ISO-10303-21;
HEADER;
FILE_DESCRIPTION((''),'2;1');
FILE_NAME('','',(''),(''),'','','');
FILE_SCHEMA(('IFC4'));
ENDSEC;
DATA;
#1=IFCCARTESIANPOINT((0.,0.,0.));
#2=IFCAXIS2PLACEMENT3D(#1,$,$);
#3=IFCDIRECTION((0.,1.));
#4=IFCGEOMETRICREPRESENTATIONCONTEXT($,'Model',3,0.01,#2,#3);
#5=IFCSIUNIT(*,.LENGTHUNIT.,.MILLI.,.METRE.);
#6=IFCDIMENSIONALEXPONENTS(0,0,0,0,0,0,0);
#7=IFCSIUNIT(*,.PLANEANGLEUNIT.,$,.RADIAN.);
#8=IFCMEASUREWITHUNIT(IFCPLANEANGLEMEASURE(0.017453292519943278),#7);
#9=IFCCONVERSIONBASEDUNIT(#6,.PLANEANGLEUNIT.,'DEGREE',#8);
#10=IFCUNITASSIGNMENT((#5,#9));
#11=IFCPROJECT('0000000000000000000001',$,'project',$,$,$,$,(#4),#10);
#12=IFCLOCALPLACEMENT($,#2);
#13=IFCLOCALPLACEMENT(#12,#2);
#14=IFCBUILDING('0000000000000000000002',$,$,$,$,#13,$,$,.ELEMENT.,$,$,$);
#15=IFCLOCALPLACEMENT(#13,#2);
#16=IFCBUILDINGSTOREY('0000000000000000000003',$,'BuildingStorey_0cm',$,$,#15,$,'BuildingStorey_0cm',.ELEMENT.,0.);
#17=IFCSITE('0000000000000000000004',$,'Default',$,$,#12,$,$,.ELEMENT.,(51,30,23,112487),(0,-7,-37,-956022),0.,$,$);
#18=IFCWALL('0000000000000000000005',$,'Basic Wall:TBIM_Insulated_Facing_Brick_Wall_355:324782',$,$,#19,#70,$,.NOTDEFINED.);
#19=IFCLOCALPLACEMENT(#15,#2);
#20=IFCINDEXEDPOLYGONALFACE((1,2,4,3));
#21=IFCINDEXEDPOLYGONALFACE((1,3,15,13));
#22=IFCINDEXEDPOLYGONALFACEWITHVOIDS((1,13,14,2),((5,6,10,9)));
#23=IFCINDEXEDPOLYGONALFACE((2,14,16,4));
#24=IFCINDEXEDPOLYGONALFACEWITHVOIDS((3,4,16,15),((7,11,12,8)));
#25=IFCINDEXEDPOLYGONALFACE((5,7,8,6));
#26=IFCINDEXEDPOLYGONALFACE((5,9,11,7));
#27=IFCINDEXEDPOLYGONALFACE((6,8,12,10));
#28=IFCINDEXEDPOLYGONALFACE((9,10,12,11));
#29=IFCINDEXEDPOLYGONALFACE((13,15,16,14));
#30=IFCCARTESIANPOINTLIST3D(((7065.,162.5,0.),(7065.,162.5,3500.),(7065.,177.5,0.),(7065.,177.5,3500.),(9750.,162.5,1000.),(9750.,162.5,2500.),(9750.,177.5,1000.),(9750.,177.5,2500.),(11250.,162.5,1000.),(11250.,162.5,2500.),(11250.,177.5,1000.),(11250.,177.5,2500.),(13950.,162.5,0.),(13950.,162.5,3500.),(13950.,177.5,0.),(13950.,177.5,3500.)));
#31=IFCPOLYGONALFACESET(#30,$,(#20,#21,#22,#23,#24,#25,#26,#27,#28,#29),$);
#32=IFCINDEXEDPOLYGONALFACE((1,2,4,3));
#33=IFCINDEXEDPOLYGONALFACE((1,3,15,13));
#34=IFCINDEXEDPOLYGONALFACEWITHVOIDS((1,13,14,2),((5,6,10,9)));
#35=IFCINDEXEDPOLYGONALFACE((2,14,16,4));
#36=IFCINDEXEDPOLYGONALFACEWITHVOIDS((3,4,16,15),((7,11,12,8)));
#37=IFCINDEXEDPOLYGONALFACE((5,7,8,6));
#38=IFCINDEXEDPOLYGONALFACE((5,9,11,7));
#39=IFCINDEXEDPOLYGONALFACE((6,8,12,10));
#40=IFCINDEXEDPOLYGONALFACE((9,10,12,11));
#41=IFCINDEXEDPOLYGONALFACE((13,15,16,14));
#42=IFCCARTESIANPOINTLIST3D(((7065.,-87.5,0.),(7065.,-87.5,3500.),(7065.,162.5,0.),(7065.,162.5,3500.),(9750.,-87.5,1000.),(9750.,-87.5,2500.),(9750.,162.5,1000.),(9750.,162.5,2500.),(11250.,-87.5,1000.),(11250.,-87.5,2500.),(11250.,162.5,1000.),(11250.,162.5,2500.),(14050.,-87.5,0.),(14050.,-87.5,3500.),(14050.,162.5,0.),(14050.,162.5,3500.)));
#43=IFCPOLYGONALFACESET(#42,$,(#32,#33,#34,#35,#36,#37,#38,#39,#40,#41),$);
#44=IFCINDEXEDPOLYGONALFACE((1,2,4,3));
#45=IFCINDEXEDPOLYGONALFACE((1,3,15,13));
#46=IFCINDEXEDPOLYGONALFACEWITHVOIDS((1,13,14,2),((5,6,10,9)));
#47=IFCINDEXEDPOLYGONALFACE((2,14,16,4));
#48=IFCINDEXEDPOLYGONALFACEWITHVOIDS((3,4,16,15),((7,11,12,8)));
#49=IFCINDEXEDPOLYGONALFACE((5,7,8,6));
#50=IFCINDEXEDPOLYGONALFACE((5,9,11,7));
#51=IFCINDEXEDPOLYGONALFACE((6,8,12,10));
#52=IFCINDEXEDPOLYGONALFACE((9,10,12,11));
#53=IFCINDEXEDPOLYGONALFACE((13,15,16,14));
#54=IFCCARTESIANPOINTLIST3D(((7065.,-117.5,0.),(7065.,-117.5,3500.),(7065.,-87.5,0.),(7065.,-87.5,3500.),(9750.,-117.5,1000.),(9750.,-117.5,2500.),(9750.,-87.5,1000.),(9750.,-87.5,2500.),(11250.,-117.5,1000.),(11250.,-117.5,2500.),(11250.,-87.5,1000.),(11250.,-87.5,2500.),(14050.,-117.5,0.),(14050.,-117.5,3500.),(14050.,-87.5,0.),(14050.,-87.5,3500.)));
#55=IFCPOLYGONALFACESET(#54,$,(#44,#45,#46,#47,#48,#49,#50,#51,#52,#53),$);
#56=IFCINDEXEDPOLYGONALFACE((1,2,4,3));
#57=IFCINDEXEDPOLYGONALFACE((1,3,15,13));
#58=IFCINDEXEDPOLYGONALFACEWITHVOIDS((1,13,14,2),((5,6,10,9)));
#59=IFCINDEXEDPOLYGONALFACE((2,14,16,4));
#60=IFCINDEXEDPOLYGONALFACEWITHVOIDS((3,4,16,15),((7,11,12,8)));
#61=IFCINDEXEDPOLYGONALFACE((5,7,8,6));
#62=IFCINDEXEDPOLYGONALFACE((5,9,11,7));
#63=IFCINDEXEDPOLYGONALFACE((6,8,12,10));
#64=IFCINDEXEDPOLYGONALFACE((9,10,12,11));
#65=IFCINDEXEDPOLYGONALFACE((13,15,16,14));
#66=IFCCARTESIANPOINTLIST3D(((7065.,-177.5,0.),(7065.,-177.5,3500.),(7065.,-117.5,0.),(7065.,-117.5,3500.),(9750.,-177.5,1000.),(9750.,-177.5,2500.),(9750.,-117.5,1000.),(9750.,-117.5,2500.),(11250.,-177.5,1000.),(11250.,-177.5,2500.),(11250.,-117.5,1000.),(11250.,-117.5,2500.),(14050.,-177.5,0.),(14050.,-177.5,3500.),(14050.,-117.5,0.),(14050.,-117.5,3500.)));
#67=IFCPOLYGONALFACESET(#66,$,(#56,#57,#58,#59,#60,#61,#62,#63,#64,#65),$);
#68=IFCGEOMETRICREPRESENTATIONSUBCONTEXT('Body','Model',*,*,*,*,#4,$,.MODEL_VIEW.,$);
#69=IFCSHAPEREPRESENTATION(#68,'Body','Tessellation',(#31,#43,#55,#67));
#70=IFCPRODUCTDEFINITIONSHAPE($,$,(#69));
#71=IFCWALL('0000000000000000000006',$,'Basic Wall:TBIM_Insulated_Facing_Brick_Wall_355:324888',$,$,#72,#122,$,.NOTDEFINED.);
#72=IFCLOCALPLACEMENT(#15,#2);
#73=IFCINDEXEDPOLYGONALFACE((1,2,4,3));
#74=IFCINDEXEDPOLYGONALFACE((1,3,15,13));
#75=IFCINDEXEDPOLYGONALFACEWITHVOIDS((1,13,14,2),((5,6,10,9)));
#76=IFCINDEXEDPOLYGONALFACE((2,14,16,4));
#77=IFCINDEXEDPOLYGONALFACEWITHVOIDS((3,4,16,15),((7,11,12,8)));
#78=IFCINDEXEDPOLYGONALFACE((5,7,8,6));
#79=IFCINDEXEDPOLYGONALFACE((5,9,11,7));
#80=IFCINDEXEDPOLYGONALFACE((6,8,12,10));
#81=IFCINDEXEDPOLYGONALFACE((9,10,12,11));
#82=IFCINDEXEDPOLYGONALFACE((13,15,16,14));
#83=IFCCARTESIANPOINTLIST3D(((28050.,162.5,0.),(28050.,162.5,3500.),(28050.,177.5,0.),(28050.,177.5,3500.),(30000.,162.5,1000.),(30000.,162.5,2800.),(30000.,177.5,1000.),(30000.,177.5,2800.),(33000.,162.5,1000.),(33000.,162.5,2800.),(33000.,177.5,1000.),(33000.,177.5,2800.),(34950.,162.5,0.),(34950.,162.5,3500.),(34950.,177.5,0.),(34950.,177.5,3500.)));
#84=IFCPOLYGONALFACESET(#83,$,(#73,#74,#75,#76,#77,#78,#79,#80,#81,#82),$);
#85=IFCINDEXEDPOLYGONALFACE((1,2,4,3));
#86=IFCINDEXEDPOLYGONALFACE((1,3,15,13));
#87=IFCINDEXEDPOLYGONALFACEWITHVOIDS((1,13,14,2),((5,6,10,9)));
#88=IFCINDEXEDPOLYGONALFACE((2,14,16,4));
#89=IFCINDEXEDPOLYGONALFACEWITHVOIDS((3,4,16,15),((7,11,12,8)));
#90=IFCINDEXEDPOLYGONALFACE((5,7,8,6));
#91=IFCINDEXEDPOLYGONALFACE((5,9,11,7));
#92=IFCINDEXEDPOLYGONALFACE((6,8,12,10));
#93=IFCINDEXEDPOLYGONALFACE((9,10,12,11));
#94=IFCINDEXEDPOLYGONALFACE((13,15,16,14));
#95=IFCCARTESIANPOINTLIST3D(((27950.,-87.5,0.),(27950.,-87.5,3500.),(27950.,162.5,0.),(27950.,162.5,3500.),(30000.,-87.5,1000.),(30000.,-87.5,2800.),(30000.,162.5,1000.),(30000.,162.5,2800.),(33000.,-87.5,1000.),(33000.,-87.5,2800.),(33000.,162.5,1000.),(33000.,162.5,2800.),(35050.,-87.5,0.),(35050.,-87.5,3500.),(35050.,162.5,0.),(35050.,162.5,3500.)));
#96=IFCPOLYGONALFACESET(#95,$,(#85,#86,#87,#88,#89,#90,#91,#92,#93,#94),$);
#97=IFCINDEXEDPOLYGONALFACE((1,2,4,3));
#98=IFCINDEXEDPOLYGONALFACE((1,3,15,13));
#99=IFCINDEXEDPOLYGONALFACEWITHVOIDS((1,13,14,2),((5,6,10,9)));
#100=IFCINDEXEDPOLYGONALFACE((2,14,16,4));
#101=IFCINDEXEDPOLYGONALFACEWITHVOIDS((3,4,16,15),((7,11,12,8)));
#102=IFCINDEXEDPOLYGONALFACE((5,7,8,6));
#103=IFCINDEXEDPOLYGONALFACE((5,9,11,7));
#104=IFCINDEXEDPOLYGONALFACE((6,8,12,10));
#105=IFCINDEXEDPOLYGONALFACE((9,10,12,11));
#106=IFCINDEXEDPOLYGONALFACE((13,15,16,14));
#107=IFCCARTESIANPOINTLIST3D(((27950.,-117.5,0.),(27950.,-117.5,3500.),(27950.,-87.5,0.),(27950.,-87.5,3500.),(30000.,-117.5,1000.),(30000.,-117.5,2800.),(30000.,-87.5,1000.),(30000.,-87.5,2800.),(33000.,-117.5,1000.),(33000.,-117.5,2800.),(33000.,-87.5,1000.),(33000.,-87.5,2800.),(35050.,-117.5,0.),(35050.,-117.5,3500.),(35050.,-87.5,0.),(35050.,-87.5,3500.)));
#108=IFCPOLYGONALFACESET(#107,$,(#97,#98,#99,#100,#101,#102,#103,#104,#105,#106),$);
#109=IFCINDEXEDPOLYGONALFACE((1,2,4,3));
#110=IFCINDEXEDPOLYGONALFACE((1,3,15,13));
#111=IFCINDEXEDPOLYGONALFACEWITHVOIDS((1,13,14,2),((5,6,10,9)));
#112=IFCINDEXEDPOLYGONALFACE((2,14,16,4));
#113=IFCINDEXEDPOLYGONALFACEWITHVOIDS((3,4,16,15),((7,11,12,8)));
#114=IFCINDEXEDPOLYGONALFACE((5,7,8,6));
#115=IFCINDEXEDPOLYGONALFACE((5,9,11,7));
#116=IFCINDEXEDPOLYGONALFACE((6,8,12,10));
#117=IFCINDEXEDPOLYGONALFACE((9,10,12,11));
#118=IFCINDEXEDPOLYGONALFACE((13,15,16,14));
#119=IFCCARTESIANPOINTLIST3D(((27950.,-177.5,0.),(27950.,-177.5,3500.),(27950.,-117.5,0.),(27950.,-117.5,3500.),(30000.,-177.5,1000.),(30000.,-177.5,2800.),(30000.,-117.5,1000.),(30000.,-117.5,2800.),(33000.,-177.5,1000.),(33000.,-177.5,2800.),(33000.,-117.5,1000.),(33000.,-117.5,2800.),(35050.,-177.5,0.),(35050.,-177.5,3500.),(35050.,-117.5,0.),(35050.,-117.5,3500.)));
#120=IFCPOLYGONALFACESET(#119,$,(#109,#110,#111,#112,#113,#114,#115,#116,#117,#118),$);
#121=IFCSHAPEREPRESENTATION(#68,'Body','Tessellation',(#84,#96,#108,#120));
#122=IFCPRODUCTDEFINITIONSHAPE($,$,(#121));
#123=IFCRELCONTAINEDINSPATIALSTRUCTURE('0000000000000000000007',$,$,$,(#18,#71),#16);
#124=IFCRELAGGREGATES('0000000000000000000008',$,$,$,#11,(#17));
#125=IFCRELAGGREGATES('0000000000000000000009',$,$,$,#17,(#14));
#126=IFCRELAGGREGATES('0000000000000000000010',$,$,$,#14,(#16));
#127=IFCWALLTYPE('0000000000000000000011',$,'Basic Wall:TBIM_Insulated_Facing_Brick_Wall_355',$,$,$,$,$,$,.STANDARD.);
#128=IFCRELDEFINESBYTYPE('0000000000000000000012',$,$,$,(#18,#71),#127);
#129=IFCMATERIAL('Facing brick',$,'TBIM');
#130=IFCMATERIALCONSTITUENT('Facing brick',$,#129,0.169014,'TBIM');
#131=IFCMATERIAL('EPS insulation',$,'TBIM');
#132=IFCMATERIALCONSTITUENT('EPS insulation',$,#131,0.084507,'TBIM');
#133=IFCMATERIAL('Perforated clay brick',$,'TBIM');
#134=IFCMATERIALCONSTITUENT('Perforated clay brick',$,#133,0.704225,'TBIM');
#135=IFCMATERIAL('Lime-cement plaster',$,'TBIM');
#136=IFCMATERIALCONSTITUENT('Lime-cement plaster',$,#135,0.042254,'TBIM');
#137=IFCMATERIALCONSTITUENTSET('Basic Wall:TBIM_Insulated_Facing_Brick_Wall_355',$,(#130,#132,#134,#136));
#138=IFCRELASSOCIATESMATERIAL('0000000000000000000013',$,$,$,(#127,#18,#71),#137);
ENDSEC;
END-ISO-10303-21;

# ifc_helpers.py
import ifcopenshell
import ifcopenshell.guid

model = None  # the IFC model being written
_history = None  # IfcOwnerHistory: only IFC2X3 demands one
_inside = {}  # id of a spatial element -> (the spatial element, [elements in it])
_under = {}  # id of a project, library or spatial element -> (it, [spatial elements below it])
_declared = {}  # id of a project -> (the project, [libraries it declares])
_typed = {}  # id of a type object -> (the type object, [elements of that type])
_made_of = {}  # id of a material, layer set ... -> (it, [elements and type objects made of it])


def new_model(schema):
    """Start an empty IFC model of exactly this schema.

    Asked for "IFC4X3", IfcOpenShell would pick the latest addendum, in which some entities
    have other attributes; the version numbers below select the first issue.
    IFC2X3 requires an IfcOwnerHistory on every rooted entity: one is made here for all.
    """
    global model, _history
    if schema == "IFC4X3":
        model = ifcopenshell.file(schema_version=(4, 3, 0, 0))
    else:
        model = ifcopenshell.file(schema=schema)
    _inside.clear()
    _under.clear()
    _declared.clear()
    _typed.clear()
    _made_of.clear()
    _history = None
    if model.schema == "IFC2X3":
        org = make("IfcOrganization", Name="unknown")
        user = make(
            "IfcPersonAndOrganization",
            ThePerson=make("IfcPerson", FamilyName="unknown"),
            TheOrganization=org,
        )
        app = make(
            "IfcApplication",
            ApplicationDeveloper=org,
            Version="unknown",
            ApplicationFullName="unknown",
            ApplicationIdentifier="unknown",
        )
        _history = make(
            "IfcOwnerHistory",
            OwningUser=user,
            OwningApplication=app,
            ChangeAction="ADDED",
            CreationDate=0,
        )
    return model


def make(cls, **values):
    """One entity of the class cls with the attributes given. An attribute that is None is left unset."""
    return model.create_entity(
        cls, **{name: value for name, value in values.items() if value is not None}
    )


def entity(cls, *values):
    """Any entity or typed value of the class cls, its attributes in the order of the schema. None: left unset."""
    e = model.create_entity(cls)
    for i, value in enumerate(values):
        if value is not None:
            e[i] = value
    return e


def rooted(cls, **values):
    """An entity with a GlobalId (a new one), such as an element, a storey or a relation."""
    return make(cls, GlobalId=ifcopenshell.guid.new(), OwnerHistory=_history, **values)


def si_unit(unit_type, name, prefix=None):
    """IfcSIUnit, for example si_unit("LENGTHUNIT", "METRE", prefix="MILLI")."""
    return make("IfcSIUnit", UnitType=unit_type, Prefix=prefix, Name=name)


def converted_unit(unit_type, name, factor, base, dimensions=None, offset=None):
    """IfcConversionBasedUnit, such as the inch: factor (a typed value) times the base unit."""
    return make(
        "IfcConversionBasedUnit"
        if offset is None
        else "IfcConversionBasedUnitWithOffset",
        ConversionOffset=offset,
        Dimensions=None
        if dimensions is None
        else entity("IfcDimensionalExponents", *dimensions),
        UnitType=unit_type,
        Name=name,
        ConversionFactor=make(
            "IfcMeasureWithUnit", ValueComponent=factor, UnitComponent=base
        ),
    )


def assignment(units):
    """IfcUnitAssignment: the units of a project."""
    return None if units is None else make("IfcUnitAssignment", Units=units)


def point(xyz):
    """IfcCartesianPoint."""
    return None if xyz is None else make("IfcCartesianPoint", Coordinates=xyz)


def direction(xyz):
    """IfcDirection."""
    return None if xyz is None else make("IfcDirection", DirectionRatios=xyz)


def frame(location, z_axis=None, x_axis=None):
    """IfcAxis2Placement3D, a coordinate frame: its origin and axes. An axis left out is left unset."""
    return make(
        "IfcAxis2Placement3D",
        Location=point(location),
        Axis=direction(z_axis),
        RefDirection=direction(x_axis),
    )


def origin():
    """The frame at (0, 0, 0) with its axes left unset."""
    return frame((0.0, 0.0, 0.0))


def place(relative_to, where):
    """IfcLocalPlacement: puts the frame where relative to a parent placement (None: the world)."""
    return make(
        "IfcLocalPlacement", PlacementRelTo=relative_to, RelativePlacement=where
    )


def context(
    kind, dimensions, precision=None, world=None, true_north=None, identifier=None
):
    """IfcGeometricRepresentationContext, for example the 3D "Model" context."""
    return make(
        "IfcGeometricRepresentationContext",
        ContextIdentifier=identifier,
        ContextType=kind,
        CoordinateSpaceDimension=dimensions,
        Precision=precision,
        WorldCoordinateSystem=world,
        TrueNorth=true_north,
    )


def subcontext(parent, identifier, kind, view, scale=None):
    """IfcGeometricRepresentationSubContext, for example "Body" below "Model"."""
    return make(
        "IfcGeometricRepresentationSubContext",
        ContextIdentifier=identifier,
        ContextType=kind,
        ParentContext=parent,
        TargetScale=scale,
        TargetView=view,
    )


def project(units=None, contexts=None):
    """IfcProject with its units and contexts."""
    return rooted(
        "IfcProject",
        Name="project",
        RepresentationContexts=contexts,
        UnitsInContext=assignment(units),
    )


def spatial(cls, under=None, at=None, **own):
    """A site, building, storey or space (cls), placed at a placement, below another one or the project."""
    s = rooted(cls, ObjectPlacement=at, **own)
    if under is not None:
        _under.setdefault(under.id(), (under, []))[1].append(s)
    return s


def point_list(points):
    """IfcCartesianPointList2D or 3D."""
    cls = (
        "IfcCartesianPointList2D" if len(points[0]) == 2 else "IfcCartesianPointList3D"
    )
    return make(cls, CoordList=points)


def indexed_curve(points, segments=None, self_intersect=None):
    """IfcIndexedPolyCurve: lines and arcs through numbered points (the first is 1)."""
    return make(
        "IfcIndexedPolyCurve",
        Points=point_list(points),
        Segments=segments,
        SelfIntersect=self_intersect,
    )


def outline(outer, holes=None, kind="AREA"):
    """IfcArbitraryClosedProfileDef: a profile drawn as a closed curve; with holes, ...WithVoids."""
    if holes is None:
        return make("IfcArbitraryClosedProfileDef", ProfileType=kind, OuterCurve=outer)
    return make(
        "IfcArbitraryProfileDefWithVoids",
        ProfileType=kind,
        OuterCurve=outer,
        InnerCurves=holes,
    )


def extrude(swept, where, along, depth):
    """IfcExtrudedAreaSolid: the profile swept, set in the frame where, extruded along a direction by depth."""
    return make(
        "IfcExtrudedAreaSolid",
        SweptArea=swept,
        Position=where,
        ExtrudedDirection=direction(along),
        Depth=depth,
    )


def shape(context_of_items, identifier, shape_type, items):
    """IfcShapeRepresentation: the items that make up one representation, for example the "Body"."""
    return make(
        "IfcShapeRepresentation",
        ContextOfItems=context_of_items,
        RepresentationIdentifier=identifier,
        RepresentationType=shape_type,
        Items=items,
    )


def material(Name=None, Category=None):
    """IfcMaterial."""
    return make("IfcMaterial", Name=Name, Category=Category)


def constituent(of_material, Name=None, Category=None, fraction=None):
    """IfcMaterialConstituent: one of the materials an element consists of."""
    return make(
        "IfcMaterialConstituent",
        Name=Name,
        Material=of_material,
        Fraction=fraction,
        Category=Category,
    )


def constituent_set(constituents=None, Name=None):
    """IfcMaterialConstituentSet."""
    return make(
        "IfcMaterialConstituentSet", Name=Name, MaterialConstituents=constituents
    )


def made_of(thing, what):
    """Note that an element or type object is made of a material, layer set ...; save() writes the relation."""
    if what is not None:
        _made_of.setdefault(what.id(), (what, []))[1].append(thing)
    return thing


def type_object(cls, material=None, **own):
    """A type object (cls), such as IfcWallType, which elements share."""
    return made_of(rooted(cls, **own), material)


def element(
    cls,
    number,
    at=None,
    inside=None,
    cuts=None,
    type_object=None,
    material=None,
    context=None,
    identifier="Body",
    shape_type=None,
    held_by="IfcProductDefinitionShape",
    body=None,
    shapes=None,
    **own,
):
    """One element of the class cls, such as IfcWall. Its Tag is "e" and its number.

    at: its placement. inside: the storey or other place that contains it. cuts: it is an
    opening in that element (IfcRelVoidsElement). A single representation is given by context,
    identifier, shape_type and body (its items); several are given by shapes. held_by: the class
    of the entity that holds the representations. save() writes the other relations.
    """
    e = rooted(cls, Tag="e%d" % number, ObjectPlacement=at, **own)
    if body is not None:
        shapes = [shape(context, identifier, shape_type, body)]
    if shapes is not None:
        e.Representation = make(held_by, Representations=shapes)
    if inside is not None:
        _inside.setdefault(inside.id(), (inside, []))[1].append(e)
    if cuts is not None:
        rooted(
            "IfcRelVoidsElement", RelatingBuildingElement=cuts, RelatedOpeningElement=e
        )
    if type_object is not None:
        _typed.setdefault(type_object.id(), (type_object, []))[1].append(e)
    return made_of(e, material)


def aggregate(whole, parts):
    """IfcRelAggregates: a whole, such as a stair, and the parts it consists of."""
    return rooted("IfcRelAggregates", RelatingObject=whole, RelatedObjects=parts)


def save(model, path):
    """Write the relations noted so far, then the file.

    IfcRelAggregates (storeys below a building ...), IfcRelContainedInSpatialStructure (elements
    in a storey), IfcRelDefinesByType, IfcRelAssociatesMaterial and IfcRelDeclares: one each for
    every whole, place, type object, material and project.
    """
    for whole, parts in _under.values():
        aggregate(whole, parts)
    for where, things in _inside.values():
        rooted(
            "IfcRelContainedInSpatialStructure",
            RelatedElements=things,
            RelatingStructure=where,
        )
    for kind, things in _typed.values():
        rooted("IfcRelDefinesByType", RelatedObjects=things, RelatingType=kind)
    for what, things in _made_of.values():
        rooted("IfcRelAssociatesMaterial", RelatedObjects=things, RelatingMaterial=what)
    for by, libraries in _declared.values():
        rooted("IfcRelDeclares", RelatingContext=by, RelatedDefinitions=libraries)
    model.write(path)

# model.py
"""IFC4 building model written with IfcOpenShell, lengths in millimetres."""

from ifc_helpers import new_model, entity, si_unit, converted_unit, direction, frame, origin, place, context, subcontext, project, spatial, indexed_curve, outline, extrude, material, constituent, constituent_set, type_object, element, save


model = new_model("IFC4")

# Units and contexts
model_context = context("Model", 3, precision=0.01, world=origin(), true_north=direction((0.0, 1.0)))
body_context = subcontext(model_context, "Body", "Model", "MODEL_VIEW")
ifc_project = project(units=[si_unit("LENGTHUNIT", "METRE", prefix="MILLI"), converted_unit("PLANEANGLEUNIT", "DEGREE", entity("IfcPlaneAngleMeasure", 0.017453292519943278), si_unit("PLANEANGLEUNIT", "RADIAN"), dimensions=[0, 0, 0, 0, 0, 0, 0])], contexts=[model_context])

# Site, building, storey
site_placement = place(None, origin())
site = spatial("IfcSite", under=ifc_project, at=site_placement, Name="Default", CompositionType="ELEMENT", RefLatitude=(51, 30, 23, 112487), RefLongitude=(0, -7, -37, -956022), RefElevation=0.0)
building_placement = place(site_placement, origin())
building = spatial("IfcBuilding", under=site, at=building_placement, CompositionType="ELEMENT")
storey_placement = place(building_placement, origin())
storey = spatial("IfcBuildingStorey", under=building, at=storey_placement, Name="BuildingStorey_0cm", LongName="BuildingStorey_0cm", CompositionType="ELEMENT", Elevation=0.0)

# Walls, openings
ifc_material_1 = material(Name="Facing brick", Category="TBIM")
ifc_constituent_1 = constituent(ifc_material_1, Name="Facing brick", Category="TBIM", fraction=0.169014)
ifc_material_2 = material(Name="EPS insulation", Category="TBIM")
ifc_constituent_2 = constituent(ifc_material_2, Name="EPS insulation", Category="TBIM", fraction=0.084507)
ifc_material_3 = material(Name="Perforated clay brick", Category="TBIM")
ifc_constituent_3 = constituent(ifc_material_3, Name="Perforated clay brick", Category="TBIM", fraction=0.704225)
ifc_material_4 = material(Name="Lime-cement plaster", Category="TBIM")
ifc_constituent_4 = constituent(ifc_material_4, Name="Lime-cement plaster", Category="TBIM", fraction=0.042254)
ifc_constituent_set_1 = constituent_set(constituents=[ifc_constituent_1, ifc_constituent_2, ifc_constituent_3, ifc_constituent_4], Name="Basic Wall:TBIM_Insulated_Facing_Brick_Wall_355")
wall_type_1 = type_object("IfcWallType", Name="Basic Wall:TBIM_Insulated_Facing_Brick_Wall_355", PredefinedType="STANDARD", material=ifc_constituent_set_1)
wall_1_placement = place(storey_placement, frame((7065.0, 0.0, 0.0)))
wall_1 = element("IfcWall", 1, at=wall_1_placement, inside=storey, type_object=wall_type_1, material=ifc_constituent_set_1, Name="Basic Wall:TBIM_Insulated_Facing_Brick_Wall_355:324782", PredefinedType="NOTDEFINED", context=body_context, shape_type="SweptSolid", body=[
    extrude(outline(indexed_curve([(-1750.0, -3442.5), (1750.0, -3442.5), (1750.0, 3442.5), (-1750.0, 3442.5), (-1750.0, -3442.5)], self_intersect=False), holes=[indexed_curve([(-750.0, -757.5), (-750.0, 742.5), (750.0, 742.5), (750.0, -757.5), (-750.0, -757.5)], self_intersect=False)]), frame((3442.5, 162.5, 1750.0), z_axis=(0.0, 1.0, 0.0), x_axis=(0.0, 0.0, 1.0)), (0.0, 0.0, 1.0), 15.0),
    extrude(outline(indexed_curve([(-1750.0, -3492.5), (1750.0, -3492.5), (1750.0, 3492.5), (-1750.0, 3492.5), (-1750.0, -3492.5)], self_intersect=False), holes=[indexed_curve([(-750.0, -807.5), (-750.0, 692.5), (750.0, 692.5), (750.0, -807.5), (-750.0, -807.5)], self_intersect=False)]), frame((3492.5, -87.5, 1750.0), z_axis=(0.0, 1.0, 0.0), x_axis=(0.0, 0.0, 1.0)), (0.0, 0.0, 1.0), 250.0),
    extrude(outline(indexed_curve([(-1750.0, -3492.5), (1750.0, -3492.5), (1750.0, 3492.5), (-1750.0, 3492.5), (-1750.0, -3492.5)], self_intersect=False), holes=[indexed_curve([(-750.0, -807.5), (-750.0, 692.5), (750.0, 692.5), (750.0, -807.5), (-750.0, -807.5)], self_intersect=False)]), frame((3492.5, -117.5, 1750.0), z_axis=(0.0, 1.0, 0.0), x_axis=(0.0, 0.0, 1.0)), (0.0, 0.0, 1.0), 30.0),
    extrude(outline(indexed_curve([(-1750.0, -3492.5), (1750.0, -3492.5), (1750.0, 3492.5), (-1750.0, 3492.5), (-1750.0, -3492.5)], self_intersect=False), holes=[indexed_curve([(750.0, -807.5), (-750.0, -807.5), (-750.0, 692.5), (750.0, 692.5), (750.0, -807.5)], self_intersect=False)]), frame((3492.5, -177.5, 1750.0), z_axis=(0.0, 1.0, 0.0), x_axis=(0.0, 0.0, 1.0)), (0.0, 0.0, 1.0), 60.0),
])
opening_1_placement = place(wall_1_placement, frame((2685.0, -177.5, 1000.0)))
element("IfcOpeningElement", 2, at=opening_1_placement, cuts=wall_1, PredefinedType="OPENING", context=body_context, shape_type="SweptSolid", body=[
    extrude(outline(indexed_curve([(1500.0, 0.0), (1500.0, 1500.0), (0.0, 1500.0), (0.0, 0.0), (1500.0, 0.0)], self_intersect=False)), frame((0.0, 0.0, 0.0), z_axis=(0.0, 1.0, 0.0), x_axis=(0.0, 0.0, 1.0)), (0.0, 0.0, 1.0), 355.0),
])
wall_2_placement = place(storey_placement, frame((27935.0, 0.0, 0.0)))
wall_2 = element("IfcWall", 3, at=wall_2_placement, inside=storey, type_object=wall_type_1, material=ifc_constituent_set_1, Name="Basic Wall:TBIM_Insulated_Facing_Brick_Wall_355:324888", PredefinedType="NOTDEFINED", context=body_context, shape_type="SweptSolid", body=[
    extrude(outline(indexed_curve([(-1750.0, -3450.0), (1750.0, -3450.0), (1750.0, 3450.0), (-1750.0, 3450.0), (-1750.0, -3450.0)], self_intersect=False), holes=[indexed_curve([(-750.0, -1500.0), (-750.0, 1500.0), (1050.0, 1500.0), (1050.0, -1500.0), (-750.0, -1500.0)], self_intersect=False)]), frame((3565.0, 162.5, 1750.0), z_axis=(0.0, 1.0, 0.0), x_axis=(0.0, 0.0, 1.0)), (0.0, 0.0, 1.0), 15.0),
    extrude(outline(indexed_curve([(-1750.0, -3550.0), (1750.0, -3550.0), (1750.0, 3550.0), (-1750.0, 3550.0), (-1750.0, -3550.0)], self_intersect=False), holes=[indexed_curve([(-750.0, -1500.0), (-750.0, 1500.0), (1050.0, 1500.0), (1050.0, -1500.0), (-750.0, -1500.0)], self_intersect=False)]), frame((3565.0, -87.5, 1750.0), z_axis=(0.0, 1.0, 0.0), x_axis=(0.0, 0.0, 1.0)), (0.0, 0.0, 1.0), 250.0),
    extrude(outline(indexed_curve([(-1750.0, -3550.0), (1750.0, -3550.0), (1750.0, 3550.0), (-1750.0, 3550.0), (-1750.0, -3550.0)], self_intersect=False), holes=[indexed_curve([(-750.0, -1500.0), (-750.0, 1500.0), (1050.0, 1500.0), (1050.0, -1500.0), (-750.0, -1500.0)], self_intersect=False)]), frame((3565.0, -117.5, 1750.0), z_axis=(0.0, 1.0, 0.0), x_axis=(0.0, 0.0, 1.0)), (0.0, 0.0, 1.0), 30.0),
    extrude(outline(indexed_curve([(-1750.0, -3550.0), (1750.0, -3550.0), (1750.0, 3550.0), (-1750.0, 3550.0), (-1750.0, -3550.0)], self_intersect=False), holes=[indexed_curve([(1050.0, -1500.0), (-750.0, -1500.0), (-750.0, 1500.0), (1050.0, 1500.0), (1050.0, -1500.0)], self_intersect=False)]), frame((3565.0, -177.5, 1750.0), z_axis=(0.0, 1.0, 0.0), x_axis=(0.0, 0.0, 1.0)), (0.0, 0.0, 1.0), 60.0),
])
opening_2_placement = place(wall_2_placement, frame((2065.0, -177.5, 1000.0)))
element("IfcOpeningElement", 4, at=opening_2_placement, cuts=wall_2, PredefinedType="OPENING", context=body_context, shape_type="SweptSolid", body=[
    extrude(outline(indexed_curve([(1800.0, 0.0), (1800.0, 3000.0), (0.0, 3000.0), (0.0, 0.0), (1800.0, 0.0)], self_intersect=False)), frame((0.0, 0.0, 0.0), z_axis=(0.0, 1.0, 0.0), x_axis=(0.0, 0.0, 1.0)), (0.0, 0.0, 1.0), 355.0),
])

save(model, "model.ifc")
